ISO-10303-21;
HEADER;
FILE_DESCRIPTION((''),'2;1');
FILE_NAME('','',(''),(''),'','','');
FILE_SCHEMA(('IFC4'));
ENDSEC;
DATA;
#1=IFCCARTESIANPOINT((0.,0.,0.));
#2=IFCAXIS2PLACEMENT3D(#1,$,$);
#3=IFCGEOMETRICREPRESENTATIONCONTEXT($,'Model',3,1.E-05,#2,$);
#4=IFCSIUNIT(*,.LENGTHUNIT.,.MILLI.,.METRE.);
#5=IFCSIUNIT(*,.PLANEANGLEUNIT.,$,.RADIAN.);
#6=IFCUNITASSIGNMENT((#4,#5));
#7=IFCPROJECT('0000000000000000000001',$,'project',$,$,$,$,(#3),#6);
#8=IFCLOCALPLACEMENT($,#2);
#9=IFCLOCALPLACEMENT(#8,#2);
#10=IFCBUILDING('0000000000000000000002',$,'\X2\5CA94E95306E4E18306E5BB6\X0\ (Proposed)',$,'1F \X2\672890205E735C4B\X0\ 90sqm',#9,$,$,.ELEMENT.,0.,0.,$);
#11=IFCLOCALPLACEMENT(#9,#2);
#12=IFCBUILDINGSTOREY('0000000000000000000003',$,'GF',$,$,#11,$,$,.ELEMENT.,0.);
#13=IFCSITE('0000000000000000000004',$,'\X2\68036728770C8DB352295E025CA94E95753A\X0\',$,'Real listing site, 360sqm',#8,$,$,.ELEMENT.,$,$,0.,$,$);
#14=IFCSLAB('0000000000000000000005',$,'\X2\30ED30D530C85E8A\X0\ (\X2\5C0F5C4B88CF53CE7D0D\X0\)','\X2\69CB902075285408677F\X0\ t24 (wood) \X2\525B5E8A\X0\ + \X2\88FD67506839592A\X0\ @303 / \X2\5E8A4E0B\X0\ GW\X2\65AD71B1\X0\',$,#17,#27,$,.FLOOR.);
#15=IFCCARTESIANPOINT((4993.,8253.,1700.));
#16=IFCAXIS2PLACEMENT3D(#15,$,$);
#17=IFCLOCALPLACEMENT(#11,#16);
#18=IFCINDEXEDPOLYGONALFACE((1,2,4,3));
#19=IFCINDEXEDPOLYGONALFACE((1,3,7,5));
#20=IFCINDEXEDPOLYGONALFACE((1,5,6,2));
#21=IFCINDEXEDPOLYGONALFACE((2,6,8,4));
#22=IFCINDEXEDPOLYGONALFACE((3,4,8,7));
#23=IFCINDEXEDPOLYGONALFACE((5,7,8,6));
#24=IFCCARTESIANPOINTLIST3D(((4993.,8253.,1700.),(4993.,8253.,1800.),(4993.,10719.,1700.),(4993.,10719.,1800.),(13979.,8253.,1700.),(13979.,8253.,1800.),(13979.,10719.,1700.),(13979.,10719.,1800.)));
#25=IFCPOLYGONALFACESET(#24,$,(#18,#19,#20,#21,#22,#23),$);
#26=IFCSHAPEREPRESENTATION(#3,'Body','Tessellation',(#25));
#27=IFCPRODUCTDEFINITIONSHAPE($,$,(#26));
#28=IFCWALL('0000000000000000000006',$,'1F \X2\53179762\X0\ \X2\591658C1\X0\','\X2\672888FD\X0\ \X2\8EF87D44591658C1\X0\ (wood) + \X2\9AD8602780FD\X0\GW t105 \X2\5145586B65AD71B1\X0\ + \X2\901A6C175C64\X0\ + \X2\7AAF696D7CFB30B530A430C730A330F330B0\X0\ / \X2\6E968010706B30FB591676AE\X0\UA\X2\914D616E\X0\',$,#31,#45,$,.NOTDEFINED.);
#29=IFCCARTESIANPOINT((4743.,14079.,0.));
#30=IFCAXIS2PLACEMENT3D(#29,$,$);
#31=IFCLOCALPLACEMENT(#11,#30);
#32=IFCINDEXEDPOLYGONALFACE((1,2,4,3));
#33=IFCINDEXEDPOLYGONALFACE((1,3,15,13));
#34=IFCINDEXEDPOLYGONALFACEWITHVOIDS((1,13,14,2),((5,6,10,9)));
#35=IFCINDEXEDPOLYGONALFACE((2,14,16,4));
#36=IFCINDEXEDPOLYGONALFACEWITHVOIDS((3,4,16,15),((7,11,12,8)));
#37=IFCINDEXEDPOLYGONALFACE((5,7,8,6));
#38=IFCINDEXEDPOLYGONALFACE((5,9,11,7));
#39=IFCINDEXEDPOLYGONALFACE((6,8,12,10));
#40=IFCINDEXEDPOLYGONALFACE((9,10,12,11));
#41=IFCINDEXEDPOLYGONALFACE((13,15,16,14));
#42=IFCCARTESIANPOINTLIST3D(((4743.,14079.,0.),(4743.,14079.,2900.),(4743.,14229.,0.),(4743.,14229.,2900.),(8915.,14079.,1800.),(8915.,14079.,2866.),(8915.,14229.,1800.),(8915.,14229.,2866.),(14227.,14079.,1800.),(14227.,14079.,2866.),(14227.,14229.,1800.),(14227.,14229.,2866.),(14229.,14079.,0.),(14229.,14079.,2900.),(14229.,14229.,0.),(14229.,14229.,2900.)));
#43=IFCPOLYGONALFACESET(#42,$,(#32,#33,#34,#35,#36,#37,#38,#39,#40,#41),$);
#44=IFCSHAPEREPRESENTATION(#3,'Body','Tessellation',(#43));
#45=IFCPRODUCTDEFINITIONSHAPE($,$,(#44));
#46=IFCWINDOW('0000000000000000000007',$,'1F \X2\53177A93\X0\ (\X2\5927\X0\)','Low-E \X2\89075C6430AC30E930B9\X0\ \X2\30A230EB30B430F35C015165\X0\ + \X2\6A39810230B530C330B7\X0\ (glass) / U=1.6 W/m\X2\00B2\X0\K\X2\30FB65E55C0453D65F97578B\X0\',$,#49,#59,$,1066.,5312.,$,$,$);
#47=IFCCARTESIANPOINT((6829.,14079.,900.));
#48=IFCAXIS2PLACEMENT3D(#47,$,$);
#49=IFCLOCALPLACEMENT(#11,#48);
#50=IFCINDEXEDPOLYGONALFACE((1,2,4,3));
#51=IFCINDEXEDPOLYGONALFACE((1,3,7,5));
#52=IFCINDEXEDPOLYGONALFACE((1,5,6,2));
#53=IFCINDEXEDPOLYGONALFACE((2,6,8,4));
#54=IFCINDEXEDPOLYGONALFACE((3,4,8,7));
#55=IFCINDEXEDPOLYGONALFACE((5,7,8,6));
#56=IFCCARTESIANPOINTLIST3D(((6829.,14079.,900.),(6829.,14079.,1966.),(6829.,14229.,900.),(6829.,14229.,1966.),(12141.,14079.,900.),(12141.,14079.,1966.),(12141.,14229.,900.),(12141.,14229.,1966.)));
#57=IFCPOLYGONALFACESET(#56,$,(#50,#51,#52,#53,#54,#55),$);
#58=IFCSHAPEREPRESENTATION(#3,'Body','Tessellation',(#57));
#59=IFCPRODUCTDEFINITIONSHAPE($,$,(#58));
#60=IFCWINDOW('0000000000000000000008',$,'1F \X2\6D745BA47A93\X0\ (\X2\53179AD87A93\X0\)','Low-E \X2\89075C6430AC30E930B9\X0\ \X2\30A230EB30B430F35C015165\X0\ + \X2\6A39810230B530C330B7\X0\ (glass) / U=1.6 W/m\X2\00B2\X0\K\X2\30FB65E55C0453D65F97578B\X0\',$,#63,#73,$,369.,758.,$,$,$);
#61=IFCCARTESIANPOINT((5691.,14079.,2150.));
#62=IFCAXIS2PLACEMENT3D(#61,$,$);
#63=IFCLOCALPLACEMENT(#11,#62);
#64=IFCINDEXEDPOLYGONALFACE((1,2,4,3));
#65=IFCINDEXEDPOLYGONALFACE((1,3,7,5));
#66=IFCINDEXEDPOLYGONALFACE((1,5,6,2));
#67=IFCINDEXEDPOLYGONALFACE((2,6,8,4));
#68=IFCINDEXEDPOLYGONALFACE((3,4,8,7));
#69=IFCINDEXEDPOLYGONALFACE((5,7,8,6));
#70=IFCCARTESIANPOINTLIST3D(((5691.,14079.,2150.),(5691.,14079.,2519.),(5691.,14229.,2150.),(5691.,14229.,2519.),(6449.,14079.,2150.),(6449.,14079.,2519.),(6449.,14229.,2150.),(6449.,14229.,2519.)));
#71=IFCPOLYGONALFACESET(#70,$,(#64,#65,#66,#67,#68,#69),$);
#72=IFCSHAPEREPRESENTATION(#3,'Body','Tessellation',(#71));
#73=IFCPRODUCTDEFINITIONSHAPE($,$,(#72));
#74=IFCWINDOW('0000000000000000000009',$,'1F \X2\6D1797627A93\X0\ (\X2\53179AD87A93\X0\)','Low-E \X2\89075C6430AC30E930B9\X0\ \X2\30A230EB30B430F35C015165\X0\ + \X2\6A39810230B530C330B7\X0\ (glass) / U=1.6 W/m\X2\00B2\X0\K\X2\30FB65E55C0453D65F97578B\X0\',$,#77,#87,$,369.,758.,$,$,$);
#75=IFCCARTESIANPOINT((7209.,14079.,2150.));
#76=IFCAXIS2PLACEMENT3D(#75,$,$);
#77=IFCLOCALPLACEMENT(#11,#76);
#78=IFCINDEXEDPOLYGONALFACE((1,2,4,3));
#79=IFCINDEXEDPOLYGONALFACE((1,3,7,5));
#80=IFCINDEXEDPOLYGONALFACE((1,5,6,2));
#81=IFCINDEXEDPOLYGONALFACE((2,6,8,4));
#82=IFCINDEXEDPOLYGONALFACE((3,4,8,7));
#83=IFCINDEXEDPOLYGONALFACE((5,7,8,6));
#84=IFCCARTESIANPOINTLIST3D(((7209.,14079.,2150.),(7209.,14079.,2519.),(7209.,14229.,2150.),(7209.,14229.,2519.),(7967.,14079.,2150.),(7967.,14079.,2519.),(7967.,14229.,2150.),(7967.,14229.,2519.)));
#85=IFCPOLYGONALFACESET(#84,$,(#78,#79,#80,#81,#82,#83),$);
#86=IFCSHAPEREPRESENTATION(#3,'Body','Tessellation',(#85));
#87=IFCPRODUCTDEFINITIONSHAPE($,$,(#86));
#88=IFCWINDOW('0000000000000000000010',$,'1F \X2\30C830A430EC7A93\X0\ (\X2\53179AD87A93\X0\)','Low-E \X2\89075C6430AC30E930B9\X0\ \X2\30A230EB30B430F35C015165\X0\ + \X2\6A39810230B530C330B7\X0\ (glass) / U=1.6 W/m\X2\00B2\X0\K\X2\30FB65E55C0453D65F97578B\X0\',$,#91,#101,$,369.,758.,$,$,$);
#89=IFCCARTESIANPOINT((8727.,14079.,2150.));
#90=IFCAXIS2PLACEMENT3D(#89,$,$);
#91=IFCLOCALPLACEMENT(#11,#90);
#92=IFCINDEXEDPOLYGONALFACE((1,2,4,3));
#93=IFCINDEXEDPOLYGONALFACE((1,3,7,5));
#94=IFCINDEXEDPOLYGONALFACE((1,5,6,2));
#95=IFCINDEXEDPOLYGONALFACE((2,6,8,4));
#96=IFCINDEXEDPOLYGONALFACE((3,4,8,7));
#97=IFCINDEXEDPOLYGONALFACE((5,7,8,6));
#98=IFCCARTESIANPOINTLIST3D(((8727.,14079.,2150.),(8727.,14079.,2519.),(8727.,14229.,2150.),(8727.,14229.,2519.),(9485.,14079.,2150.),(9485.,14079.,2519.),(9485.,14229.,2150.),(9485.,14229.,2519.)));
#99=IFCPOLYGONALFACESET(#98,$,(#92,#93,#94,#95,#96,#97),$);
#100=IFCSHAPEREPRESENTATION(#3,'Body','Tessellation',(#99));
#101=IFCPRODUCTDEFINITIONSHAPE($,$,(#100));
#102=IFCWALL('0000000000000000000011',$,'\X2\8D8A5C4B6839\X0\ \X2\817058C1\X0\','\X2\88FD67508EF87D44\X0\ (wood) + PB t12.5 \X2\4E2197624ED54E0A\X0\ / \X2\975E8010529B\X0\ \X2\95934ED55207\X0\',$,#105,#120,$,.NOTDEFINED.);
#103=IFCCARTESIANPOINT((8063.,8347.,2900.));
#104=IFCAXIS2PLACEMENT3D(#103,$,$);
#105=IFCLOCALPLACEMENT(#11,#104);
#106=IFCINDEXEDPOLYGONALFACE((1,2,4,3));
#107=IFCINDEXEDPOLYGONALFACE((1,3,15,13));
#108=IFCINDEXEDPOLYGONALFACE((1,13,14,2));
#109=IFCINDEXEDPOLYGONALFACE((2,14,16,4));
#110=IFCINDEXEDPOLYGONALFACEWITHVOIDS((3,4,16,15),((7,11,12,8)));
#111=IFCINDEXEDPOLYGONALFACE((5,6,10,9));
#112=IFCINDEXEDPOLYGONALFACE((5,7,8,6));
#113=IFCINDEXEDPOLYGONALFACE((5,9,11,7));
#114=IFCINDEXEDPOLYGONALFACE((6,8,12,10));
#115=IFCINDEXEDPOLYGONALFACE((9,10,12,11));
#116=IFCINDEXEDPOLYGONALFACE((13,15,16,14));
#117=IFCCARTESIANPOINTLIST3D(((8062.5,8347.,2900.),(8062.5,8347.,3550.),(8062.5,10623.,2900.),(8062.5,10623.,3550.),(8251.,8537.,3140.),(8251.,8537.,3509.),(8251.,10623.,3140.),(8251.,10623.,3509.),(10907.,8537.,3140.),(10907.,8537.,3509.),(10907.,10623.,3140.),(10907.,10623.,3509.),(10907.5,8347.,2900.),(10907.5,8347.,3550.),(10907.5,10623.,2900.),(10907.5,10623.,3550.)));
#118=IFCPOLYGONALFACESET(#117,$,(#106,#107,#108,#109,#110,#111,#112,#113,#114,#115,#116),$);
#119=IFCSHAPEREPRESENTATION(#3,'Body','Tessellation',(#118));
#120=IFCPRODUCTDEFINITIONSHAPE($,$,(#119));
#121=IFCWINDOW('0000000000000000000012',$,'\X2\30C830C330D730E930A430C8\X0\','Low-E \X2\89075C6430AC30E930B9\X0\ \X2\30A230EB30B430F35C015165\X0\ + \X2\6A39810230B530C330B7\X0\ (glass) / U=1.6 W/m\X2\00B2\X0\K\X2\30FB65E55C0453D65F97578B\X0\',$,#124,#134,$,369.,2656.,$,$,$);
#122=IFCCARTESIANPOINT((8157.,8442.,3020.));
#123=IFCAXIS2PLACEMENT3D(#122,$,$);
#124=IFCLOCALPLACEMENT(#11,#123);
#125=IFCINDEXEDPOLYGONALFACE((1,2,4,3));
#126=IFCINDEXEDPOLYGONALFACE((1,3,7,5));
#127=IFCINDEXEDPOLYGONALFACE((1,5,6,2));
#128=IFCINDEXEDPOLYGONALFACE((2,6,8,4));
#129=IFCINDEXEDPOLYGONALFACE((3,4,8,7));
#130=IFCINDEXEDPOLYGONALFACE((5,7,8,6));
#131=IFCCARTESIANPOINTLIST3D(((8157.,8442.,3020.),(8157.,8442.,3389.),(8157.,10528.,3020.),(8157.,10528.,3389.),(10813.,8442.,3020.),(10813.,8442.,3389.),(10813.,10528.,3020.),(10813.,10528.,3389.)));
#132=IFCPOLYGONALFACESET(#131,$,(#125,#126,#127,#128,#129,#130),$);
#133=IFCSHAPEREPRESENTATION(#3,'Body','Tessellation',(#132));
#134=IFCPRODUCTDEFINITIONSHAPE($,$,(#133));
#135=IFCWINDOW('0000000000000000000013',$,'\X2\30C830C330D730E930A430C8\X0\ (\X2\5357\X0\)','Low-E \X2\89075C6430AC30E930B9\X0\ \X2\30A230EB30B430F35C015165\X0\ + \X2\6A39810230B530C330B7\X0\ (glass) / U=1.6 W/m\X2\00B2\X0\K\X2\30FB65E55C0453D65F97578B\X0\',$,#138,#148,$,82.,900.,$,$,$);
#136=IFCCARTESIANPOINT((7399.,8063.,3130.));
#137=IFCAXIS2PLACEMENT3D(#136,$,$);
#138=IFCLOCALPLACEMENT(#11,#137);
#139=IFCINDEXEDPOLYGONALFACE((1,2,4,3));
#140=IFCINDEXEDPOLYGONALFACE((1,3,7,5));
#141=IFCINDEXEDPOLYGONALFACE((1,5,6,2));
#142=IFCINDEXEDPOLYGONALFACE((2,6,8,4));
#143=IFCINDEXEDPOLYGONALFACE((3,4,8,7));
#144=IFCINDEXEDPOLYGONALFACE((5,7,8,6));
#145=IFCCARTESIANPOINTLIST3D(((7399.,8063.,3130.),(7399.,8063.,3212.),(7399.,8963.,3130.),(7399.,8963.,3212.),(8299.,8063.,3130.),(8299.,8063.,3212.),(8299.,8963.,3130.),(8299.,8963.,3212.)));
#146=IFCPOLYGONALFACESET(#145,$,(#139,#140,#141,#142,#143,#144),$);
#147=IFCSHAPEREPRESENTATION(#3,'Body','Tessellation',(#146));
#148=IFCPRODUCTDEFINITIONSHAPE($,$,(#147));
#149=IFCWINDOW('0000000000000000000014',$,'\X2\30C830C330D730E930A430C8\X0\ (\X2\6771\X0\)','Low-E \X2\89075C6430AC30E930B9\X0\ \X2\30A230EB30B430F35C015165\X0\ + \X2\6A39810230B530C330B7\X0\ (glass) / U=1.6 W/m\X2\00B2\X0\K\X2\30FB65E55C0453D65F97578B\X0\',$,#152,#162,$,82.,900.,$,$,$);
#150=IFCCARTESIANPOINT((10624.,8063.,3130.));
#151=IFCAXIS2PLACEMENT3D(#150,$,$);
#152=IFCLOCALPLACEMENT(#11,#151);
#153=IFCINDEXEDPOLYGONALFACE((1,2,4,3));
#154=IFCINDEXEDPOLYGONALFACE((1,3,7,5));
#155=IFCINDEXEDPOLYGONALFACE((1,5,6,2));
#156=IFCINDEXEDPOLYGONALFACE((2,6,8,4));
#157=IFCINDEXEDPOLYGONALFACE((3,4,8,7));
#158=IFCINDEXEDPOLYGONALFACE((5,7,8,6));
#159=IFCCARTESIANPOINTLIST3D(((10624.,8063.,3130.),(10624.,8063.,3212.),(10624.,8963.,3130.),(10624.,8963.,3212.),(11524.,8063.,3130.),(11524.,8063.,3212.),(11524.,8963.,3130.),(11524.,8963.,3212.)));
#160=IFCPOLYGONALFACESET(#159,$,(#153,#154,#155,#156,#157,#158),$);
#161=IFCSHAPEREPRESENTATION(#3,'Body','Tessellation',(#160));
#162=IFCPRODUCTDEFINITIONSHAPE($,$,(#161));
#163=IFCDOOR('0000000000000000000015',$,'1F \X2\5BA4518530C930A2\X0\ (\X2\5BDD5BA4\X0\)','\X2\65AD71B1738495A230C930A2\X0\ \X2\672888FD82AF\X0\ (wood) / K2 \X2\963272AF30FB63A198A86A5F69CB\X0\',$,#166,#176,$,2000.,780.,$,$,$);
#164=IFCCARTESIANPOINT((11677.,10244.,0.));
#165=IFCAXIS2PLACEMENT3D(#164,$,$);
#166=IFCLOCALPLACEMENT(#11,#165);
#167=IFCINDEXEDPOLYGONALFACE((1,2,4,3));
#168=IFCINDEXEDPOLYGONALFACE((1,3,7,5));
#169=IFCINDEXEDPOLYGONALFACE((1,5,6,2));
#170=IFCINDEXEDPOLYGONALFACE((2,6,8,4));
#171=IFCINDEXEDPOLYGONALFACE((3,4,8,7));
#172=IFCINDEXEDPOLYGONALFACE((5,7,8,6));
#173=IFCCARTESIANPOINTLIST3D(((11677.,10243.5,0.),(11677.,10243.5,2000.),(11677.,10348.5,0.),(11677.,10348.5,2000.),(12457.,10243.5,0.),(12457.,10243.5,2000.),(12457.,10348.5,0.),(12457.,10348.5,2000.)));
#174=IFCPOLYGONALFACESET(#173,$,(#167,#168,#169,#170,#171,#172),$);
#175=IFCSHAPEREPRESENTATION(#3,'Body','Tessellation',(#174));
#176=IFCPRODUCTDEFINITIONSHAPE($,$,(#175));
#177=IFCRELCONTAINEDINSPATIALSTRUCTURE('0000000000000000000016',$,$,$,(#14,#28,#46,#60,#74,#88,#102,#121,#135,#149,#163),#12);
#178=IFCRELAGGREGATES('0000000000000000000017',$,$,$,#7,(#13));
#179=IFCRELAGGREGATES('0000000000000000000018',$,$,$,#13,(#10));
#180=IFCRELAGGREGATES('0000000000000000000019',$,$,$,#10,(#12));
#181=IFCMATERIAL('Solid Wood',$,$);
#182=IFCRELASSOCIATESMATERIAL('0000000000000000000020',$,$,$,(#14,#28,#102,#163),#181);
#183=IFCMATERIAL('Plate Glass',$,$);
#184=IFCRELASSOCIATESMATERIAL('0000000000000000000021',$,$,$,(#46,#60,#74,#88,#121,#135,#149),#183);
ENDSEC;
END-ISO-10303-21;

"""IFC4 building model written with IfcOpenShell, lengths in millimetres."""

from ifc_helpers import new_model, si_unit, frame, frame_2d, origin, place, context, project, spatial, rectangle, extrude, material, element, fill, save


model = new_model("IFC4")

# Units and contexts
model_context = context("Model", 3, precision=1e-05, world=origin())
ifc_project = project(units=[si_unit("LENGTHUNIT", "METRE", prefix="MILLI"), si_unit("PLANEANGLEUNIT", "RADIAN")], contexts=[model_context])

# Site, building, storey
site_placement = place(None, origin())
site = spatial("IfcSite", under=ifc_project, at=site_placement, Name="栃木県足利市岩井町", ObjectType="Real listing site, 360sqm", CompositionType="ELEMENT", RefElevation=0.0)
building_placement = place(site_placement, origin())
building = spatial("IfcBuilding", under=site, at=building_placement, Name="岩井の丘の家 (Proposed)", ObjectType="1F 木造平屋 90sqm", CompositionType="ELEMENT", ElevationOfRefHeight=0.0, ElevationOfTerrain=0.0)
storey_placement = place(building_placement, origin())
storey = spatial("IfcBuildingStorey", under=building, at=storey_placement, Name="GF", CompositionType="ELEMENT", Elevation=0.0)

# Slab
ifc_material_1 = material(Name="Solid Wood")
slab_placement = place(storey_placement, frame((4993.0, 8253.0, 1700.0)))
element("IfcSlab", 1, at=slab_placement, inside=storey, material=ifc_material_1, Name="ロフト床 (小屋裏収納)", Description="構造用合板 t24 (wood) 剛床 + 製材根太 @303 / 床下 GW断熱", PredefinedType="FLOOR", context=model_context, shape_type="SweptSolid", body=[
    extrude(rectangle(XDim=8986.0, YDim=2466.0, at=frame_2d((4493.0, 1233.0))), frame((4993.0, 8253.0, 1700.0)), (0.0, 0.0, 1.0), 100.0),
])

# Wall, openings, windows
wall_1_placement = place(storey_placement, frame((4743.0, 14079.0, 0.0)))
wall_1 = element("IfcWall", 2, at=wall_1_placement, inside=storey, material=ifc_material_1, Name="1F 北面 外壁", Description="木製 軸組外壁 (wood) + 高性能GW t105 充填断熱 + 通気層 + 窯業系サイディング / 準耐火・外皮UA配慮", PredefinedType="NOTDEFINED", context=model_context, shape_type="SweptSolid", body=[
    extrude(rectangle(XDim=9486.0, YDim=150.0, at=frame_2d((4743.0, 75.0))), frame((4743.0, 14079.0, 0.0)), (0.0, 0.0, 1.0), 2900.0),
])
opening_1_placement = place(storey_placement, frame((6829.0, 14079.0, 900.0)))
opening_1 = element("IfcOpeningElement", 3, at=opening_1_placement, cuts=wall_1, PredefinedType="NOTDEFINED", context=model_context, shape_type="SweptSolid", body=[
    extrude(rectangle(XDim=5312.0, YDim=150.0, at=frame_2d((2656.0, 75.0))), frame((6829.0, 14079.0, 900.0)), (0.0, 0.0, 1.0), 1066.0),
])
opening_2_placement = place(storey_placement, frame((5691.0, 14079.0, 2150.0)))
opening_2 = element("IfcOpeningElement", 4, at=opening_2_placement, cuts=wall_1, PredefinedType="NOTDEFINED", context=model_context, shape_type="SweptSolid", body=[
    extrude(rectangle(XDim=758.0, YDim=150.0, at=frame_2d((379.0, 75.0))), frame((5691.0, 14079.0, 2150.0)), (0.0, 0.0, 1.0), 369.0),
])
opening_3_placement = place(storey_placement, frame((7209.0, 14079.0, 2150.0)))
opening_3 = element("IfcOpeningElement", 5, at=opening_3_placement, cuts=wall_1, PredefinedType="NOTDEFINED", context=model_context, shape_type="SweptSolid", body=[
    extrude(rectangle(XDim=758.0, YDim=150.0, at=frame_2d((379.0, 75.0))), frame((7209.0, 14079.0, 2150.0)), (0.0, 0.0, 1.0), 369.0),
])
opening_4_placement = place(storey_placement, frame((8727.0, 14079.0, 2150.0)))
opening_4 = element("IfcOpeningElement", 6, at=opening_4_placement, cuts=wall_1, PredefinedType="NOTDEFINED", context=model_context, shape_type="SweptSolid", body=[
    extrude(rectangle(XDim=758.0, YDim=150.0, at=frame_2d((379.0, 75.0))), frame((8727.0, 14079.0, 2150.0)), (0.0, 0.0, 1.0), 369.0),
])
ifc_material_2 = material(Name="Plate Glass")
window_1_placement = place(storey_placement, frame((6829.0, 14079.0, 900.0)))
window_1 = element("IfcWindow", 7, at=window_1_placement, inside=storey, material=ifc_material_2, Name="1F 北窓 (大)", Description="Low-E 複層ガラス アルゴン封入 + 樹脂サッシ (glass) / U=1.6 W/m²K・日射取得型", OverallHeight=1066.0, OverallWidth=5312.0, context=model_context, shape_type="SweptSolid", body=[
    extrude(rectangle(XDim=5312.0, YDim=150.0, at=frame_2d((2656.0, 75.0))), frame((6829.0, 14079.0, 900.0)), (0.0, 0.0, 1.0), 1066.0),
])
fill(opening_1, window_1)
window_2_placement = place(storey_placement, frame((5691.0, 14079.0, 2150.0)))
window_2 = element("IfcWindow", 8, at=window_2_placement, inside=storey, material=ifc_material_2, Name="1F 浴室窓 (北高窓)", Description="Low-E 複層ガラス アルゴン封入 + 樹脂サッシ (glass) / U=1.6 W/m²K・日射取得型", OverallHeight=369.0, OverallWidth=758.0, context=model_context, shape_type="SweptSolid", body=[
    extrude(rectangle(XDim=758.0, YDim=150.0, at=frame_2d((379.0, 75.0))), frame((5691.0, 14079.0, 2150.0)), (0.0, 0.0, 1.0), 369.0),
])
fill(opening_2, window_2)
window_3_placement = place(storey_placement, frame((7209.0, 14079.0, 2150.0)))
window_3 = element("IfcWindow", 9, at=window_3_placement, inside=storey, material=ifc_material_2, Name="1F 洗面窓 (北高窓)", Description="Low-E 複層ガラス アルゴン封入 + 樹脂サッシ (glass) / U=1.6 W/m²K・日射取得型", OverallHeight=369.0, OverallWidth=758.0, context=model_context, shape_type="SweptSolid", body=[
    extrude(rectangle(XDim=758.0, YDim=150.0, at=frame_2d((379.0, 75.0))), frame((7209.0, 14079.0, 2150.0)), (0.0, 0.0, 1.0), 369.0),
])
fill(opening_3, window_3)
window_4_placement = place(storey_placement, frame((8727.0, 14079.0, 2150.0)))
window_4 = element("IfcWindow", 10, at=window_4_placement, inside=storey, material=ifc_material_2, Name="1F トイレ窓 (北高窓)", Description="Low-E 複層ガラス アルゴン封入 + 樹脂サッシ (glass) / U=1.6 W/m²K・日射取得型", OverallHeight=369.0, OverallWidth=758.0, context=model_context, shape_type="SweptSolid", body=[
    extrude(rectangle(XDim=758.0, YDim=150.0, at=frame_2d((379.0, 75.0))), frame((8727.0, 14079.0, 2150.0)), (0.0, 0.0, 1.0), 369.0),
])
fill(opening_4, window_4)

# Wall, openings, windows
wall_2_placement = place(storey_placement, frame((8063.0, 8347.0, 2900.0)))
wall_2 = element("IfcWall", 11, at=wall_2_placement, inside=storey, material=ifc_material_1, Name="越屋根 腰壁", Description="製材軸組 (wood) + PB t12.5 両面仕上 / 非耐力 間仕切", PredefinedType="NOTDEFINED", context=model_context, shape_type="SweptSolid", body=[
    extrude(rectangle(XDim=2845.0, YDim=2276.0, at=frame_2d((1422.0, 1138.0))), frame((8063.0, 8347.0, 2900.0)), (0.0, 0.0, 1.0), 650.0),
])
opening_5_placement = place(storey_placement, frame((8157.0, 8442.0, 3020.0)))
opening_5 = element("IfcOpeningElement", 12, at=opening_5_placement, cuts=wall_2, PredefinedType="NOTDEFINED", context=model_context, shape_type="SweptSolid", body=[
    extrude(rectangle(XDim=2656.0, YDim=2086.0, at=frame_2d((1328.0, 1043.0))), frame((8157.0, 8442.0, 3020.0)), (0.0, 0.0, 1.0), 369.0),
])
opening_6_placement = place(storey_placement, frame((7399.0, 8063.0, 3130.0)))
opening_6 = element("IfcOpeningElement", 13, at=opening_6_placement, cuts=wall_2, PredefinedType="NOTDEFINED", context=model_context, shape_type="SweptSolid", body=[
    extrude(rectangle(XDim=900.0, YDim=900.0, at=frame_2d((450.0, 450.0))), frame((7399.0, 8063.0, 3130.0)), (0.0, 0.0, 1.0), 82.0),
])
opening_7_placement = place(storey_placement, frame((10624.0, 8063.0, 3130.0)))
opening_7 = element("IfcOpeningElement", 14, at=opening_7_placement, cuts=wall_2, PredefinedType="NOTDEFINED", context=model_context, shape_type="SweptSolid", body=[
    extrude(rectangle(XDim=900.0, YDim=900.0, at=frame_2d((450.0, 450.0))), frame((10624.0, 8063.0, 3130.0)), (0.0, 0.0, 1.0), 82.0),
])
window_5_placement = place(storey_placement, frame((8157.0, 8442.0, 3020.0)))
window_5 = element("IfcWindow", 15, at=window_5_placement, inside=storey, material=ifc_material_2, Name="トップライト", Description="Low-E 複層ガラス アルゴン封入 + 樹脂サッシ (glass) / U=1.6 W/m²K・日射取得型", OverallHeight=369.0, OverallWidth=2656.0, context=model_context, shape_type="SweptSolid", body=[
    extrude(rectangle(XDim=2656.0, YDim=2086.0, at=frame_2d((1328.0, 1043.0))), frame((8157.0, 8442.0, 3020.0)), (0.0, 0.0, 1.0), 369.0),
])
fill(opening_5, window_5)
window_6_placement = place(storey_placement, frame((7399.0, 8063.0, 3130.0)))
window_6 = element("IfcWindow", 16, at=window_6_placement, inside=storey, material=ifc_material_2, Name="トップライト (南)", Description="Low-E 複層ガラス アルゴン封入 + 樹脂サッシ (glass) / U=1.6 W/m²K・日射取得型", OverallHeight=82.0, OverallWidth=900.0, context=model_context, shape_type="SweptSolid", body=[
    extrude(rectangle(XDim=900.0, YDim=900.0, at=frame_2d((450.0, 450.0))), frame((7399.0, 8063.0, 3130.0)), (0.0, 0.0, 1.0), 82.0),
])
fill(opening_6, window_6)
window_7_placement = place(storey_placement, frame((10624.0, 8063.0, 3130.0)))
window_7 = element("IfcWindow", 17, at=window_7_placement, inside=storey, material=ifc_material_2, Name="トップライト (東)", Description="Low-E 複層ガラス アルゴン封入 + 樹脂サッシ (glass) / U=1.6 W/m²K・日射取得型", OverallHeight=82.0, OverallWidth=900.0, context=model_context, shape_type="SweptSolid", body=[
    extrude(rectangle(XDim=900.0, YDim=900.0, at=frame_2d((450.0, 450.0))), frame((10624.0, 8063.0, 3130.0)), (0.0, 0.0, 1.0), 82.0),
])
fill(opening_7, window_7)

# Door
door_1_placement = place(storey_placement, frame((11677.0, 10244.0, 0.0)))
element("IfcDoor", 18, at=door_1_placement, inside=storey, material=ifc_material_1, Name="1F 室内ドア (寝室)", Description="断熱玄関ドア 木製芯 (wood) / K2 防犯・採風機構", OverallHeight=2000.0, OverallWidth=780.0, context=model_context, shape_type="SweptSolid", body=[
    extrude(rectangle(XDim=780.0, YDim=105.0, at=frame_2d((390.0, 52.0))), frame((11677.0, 10244.0, 0.0)), (0.0, 0.0, 1.0), 2000.0),
])

save(model, "model.ifc")
